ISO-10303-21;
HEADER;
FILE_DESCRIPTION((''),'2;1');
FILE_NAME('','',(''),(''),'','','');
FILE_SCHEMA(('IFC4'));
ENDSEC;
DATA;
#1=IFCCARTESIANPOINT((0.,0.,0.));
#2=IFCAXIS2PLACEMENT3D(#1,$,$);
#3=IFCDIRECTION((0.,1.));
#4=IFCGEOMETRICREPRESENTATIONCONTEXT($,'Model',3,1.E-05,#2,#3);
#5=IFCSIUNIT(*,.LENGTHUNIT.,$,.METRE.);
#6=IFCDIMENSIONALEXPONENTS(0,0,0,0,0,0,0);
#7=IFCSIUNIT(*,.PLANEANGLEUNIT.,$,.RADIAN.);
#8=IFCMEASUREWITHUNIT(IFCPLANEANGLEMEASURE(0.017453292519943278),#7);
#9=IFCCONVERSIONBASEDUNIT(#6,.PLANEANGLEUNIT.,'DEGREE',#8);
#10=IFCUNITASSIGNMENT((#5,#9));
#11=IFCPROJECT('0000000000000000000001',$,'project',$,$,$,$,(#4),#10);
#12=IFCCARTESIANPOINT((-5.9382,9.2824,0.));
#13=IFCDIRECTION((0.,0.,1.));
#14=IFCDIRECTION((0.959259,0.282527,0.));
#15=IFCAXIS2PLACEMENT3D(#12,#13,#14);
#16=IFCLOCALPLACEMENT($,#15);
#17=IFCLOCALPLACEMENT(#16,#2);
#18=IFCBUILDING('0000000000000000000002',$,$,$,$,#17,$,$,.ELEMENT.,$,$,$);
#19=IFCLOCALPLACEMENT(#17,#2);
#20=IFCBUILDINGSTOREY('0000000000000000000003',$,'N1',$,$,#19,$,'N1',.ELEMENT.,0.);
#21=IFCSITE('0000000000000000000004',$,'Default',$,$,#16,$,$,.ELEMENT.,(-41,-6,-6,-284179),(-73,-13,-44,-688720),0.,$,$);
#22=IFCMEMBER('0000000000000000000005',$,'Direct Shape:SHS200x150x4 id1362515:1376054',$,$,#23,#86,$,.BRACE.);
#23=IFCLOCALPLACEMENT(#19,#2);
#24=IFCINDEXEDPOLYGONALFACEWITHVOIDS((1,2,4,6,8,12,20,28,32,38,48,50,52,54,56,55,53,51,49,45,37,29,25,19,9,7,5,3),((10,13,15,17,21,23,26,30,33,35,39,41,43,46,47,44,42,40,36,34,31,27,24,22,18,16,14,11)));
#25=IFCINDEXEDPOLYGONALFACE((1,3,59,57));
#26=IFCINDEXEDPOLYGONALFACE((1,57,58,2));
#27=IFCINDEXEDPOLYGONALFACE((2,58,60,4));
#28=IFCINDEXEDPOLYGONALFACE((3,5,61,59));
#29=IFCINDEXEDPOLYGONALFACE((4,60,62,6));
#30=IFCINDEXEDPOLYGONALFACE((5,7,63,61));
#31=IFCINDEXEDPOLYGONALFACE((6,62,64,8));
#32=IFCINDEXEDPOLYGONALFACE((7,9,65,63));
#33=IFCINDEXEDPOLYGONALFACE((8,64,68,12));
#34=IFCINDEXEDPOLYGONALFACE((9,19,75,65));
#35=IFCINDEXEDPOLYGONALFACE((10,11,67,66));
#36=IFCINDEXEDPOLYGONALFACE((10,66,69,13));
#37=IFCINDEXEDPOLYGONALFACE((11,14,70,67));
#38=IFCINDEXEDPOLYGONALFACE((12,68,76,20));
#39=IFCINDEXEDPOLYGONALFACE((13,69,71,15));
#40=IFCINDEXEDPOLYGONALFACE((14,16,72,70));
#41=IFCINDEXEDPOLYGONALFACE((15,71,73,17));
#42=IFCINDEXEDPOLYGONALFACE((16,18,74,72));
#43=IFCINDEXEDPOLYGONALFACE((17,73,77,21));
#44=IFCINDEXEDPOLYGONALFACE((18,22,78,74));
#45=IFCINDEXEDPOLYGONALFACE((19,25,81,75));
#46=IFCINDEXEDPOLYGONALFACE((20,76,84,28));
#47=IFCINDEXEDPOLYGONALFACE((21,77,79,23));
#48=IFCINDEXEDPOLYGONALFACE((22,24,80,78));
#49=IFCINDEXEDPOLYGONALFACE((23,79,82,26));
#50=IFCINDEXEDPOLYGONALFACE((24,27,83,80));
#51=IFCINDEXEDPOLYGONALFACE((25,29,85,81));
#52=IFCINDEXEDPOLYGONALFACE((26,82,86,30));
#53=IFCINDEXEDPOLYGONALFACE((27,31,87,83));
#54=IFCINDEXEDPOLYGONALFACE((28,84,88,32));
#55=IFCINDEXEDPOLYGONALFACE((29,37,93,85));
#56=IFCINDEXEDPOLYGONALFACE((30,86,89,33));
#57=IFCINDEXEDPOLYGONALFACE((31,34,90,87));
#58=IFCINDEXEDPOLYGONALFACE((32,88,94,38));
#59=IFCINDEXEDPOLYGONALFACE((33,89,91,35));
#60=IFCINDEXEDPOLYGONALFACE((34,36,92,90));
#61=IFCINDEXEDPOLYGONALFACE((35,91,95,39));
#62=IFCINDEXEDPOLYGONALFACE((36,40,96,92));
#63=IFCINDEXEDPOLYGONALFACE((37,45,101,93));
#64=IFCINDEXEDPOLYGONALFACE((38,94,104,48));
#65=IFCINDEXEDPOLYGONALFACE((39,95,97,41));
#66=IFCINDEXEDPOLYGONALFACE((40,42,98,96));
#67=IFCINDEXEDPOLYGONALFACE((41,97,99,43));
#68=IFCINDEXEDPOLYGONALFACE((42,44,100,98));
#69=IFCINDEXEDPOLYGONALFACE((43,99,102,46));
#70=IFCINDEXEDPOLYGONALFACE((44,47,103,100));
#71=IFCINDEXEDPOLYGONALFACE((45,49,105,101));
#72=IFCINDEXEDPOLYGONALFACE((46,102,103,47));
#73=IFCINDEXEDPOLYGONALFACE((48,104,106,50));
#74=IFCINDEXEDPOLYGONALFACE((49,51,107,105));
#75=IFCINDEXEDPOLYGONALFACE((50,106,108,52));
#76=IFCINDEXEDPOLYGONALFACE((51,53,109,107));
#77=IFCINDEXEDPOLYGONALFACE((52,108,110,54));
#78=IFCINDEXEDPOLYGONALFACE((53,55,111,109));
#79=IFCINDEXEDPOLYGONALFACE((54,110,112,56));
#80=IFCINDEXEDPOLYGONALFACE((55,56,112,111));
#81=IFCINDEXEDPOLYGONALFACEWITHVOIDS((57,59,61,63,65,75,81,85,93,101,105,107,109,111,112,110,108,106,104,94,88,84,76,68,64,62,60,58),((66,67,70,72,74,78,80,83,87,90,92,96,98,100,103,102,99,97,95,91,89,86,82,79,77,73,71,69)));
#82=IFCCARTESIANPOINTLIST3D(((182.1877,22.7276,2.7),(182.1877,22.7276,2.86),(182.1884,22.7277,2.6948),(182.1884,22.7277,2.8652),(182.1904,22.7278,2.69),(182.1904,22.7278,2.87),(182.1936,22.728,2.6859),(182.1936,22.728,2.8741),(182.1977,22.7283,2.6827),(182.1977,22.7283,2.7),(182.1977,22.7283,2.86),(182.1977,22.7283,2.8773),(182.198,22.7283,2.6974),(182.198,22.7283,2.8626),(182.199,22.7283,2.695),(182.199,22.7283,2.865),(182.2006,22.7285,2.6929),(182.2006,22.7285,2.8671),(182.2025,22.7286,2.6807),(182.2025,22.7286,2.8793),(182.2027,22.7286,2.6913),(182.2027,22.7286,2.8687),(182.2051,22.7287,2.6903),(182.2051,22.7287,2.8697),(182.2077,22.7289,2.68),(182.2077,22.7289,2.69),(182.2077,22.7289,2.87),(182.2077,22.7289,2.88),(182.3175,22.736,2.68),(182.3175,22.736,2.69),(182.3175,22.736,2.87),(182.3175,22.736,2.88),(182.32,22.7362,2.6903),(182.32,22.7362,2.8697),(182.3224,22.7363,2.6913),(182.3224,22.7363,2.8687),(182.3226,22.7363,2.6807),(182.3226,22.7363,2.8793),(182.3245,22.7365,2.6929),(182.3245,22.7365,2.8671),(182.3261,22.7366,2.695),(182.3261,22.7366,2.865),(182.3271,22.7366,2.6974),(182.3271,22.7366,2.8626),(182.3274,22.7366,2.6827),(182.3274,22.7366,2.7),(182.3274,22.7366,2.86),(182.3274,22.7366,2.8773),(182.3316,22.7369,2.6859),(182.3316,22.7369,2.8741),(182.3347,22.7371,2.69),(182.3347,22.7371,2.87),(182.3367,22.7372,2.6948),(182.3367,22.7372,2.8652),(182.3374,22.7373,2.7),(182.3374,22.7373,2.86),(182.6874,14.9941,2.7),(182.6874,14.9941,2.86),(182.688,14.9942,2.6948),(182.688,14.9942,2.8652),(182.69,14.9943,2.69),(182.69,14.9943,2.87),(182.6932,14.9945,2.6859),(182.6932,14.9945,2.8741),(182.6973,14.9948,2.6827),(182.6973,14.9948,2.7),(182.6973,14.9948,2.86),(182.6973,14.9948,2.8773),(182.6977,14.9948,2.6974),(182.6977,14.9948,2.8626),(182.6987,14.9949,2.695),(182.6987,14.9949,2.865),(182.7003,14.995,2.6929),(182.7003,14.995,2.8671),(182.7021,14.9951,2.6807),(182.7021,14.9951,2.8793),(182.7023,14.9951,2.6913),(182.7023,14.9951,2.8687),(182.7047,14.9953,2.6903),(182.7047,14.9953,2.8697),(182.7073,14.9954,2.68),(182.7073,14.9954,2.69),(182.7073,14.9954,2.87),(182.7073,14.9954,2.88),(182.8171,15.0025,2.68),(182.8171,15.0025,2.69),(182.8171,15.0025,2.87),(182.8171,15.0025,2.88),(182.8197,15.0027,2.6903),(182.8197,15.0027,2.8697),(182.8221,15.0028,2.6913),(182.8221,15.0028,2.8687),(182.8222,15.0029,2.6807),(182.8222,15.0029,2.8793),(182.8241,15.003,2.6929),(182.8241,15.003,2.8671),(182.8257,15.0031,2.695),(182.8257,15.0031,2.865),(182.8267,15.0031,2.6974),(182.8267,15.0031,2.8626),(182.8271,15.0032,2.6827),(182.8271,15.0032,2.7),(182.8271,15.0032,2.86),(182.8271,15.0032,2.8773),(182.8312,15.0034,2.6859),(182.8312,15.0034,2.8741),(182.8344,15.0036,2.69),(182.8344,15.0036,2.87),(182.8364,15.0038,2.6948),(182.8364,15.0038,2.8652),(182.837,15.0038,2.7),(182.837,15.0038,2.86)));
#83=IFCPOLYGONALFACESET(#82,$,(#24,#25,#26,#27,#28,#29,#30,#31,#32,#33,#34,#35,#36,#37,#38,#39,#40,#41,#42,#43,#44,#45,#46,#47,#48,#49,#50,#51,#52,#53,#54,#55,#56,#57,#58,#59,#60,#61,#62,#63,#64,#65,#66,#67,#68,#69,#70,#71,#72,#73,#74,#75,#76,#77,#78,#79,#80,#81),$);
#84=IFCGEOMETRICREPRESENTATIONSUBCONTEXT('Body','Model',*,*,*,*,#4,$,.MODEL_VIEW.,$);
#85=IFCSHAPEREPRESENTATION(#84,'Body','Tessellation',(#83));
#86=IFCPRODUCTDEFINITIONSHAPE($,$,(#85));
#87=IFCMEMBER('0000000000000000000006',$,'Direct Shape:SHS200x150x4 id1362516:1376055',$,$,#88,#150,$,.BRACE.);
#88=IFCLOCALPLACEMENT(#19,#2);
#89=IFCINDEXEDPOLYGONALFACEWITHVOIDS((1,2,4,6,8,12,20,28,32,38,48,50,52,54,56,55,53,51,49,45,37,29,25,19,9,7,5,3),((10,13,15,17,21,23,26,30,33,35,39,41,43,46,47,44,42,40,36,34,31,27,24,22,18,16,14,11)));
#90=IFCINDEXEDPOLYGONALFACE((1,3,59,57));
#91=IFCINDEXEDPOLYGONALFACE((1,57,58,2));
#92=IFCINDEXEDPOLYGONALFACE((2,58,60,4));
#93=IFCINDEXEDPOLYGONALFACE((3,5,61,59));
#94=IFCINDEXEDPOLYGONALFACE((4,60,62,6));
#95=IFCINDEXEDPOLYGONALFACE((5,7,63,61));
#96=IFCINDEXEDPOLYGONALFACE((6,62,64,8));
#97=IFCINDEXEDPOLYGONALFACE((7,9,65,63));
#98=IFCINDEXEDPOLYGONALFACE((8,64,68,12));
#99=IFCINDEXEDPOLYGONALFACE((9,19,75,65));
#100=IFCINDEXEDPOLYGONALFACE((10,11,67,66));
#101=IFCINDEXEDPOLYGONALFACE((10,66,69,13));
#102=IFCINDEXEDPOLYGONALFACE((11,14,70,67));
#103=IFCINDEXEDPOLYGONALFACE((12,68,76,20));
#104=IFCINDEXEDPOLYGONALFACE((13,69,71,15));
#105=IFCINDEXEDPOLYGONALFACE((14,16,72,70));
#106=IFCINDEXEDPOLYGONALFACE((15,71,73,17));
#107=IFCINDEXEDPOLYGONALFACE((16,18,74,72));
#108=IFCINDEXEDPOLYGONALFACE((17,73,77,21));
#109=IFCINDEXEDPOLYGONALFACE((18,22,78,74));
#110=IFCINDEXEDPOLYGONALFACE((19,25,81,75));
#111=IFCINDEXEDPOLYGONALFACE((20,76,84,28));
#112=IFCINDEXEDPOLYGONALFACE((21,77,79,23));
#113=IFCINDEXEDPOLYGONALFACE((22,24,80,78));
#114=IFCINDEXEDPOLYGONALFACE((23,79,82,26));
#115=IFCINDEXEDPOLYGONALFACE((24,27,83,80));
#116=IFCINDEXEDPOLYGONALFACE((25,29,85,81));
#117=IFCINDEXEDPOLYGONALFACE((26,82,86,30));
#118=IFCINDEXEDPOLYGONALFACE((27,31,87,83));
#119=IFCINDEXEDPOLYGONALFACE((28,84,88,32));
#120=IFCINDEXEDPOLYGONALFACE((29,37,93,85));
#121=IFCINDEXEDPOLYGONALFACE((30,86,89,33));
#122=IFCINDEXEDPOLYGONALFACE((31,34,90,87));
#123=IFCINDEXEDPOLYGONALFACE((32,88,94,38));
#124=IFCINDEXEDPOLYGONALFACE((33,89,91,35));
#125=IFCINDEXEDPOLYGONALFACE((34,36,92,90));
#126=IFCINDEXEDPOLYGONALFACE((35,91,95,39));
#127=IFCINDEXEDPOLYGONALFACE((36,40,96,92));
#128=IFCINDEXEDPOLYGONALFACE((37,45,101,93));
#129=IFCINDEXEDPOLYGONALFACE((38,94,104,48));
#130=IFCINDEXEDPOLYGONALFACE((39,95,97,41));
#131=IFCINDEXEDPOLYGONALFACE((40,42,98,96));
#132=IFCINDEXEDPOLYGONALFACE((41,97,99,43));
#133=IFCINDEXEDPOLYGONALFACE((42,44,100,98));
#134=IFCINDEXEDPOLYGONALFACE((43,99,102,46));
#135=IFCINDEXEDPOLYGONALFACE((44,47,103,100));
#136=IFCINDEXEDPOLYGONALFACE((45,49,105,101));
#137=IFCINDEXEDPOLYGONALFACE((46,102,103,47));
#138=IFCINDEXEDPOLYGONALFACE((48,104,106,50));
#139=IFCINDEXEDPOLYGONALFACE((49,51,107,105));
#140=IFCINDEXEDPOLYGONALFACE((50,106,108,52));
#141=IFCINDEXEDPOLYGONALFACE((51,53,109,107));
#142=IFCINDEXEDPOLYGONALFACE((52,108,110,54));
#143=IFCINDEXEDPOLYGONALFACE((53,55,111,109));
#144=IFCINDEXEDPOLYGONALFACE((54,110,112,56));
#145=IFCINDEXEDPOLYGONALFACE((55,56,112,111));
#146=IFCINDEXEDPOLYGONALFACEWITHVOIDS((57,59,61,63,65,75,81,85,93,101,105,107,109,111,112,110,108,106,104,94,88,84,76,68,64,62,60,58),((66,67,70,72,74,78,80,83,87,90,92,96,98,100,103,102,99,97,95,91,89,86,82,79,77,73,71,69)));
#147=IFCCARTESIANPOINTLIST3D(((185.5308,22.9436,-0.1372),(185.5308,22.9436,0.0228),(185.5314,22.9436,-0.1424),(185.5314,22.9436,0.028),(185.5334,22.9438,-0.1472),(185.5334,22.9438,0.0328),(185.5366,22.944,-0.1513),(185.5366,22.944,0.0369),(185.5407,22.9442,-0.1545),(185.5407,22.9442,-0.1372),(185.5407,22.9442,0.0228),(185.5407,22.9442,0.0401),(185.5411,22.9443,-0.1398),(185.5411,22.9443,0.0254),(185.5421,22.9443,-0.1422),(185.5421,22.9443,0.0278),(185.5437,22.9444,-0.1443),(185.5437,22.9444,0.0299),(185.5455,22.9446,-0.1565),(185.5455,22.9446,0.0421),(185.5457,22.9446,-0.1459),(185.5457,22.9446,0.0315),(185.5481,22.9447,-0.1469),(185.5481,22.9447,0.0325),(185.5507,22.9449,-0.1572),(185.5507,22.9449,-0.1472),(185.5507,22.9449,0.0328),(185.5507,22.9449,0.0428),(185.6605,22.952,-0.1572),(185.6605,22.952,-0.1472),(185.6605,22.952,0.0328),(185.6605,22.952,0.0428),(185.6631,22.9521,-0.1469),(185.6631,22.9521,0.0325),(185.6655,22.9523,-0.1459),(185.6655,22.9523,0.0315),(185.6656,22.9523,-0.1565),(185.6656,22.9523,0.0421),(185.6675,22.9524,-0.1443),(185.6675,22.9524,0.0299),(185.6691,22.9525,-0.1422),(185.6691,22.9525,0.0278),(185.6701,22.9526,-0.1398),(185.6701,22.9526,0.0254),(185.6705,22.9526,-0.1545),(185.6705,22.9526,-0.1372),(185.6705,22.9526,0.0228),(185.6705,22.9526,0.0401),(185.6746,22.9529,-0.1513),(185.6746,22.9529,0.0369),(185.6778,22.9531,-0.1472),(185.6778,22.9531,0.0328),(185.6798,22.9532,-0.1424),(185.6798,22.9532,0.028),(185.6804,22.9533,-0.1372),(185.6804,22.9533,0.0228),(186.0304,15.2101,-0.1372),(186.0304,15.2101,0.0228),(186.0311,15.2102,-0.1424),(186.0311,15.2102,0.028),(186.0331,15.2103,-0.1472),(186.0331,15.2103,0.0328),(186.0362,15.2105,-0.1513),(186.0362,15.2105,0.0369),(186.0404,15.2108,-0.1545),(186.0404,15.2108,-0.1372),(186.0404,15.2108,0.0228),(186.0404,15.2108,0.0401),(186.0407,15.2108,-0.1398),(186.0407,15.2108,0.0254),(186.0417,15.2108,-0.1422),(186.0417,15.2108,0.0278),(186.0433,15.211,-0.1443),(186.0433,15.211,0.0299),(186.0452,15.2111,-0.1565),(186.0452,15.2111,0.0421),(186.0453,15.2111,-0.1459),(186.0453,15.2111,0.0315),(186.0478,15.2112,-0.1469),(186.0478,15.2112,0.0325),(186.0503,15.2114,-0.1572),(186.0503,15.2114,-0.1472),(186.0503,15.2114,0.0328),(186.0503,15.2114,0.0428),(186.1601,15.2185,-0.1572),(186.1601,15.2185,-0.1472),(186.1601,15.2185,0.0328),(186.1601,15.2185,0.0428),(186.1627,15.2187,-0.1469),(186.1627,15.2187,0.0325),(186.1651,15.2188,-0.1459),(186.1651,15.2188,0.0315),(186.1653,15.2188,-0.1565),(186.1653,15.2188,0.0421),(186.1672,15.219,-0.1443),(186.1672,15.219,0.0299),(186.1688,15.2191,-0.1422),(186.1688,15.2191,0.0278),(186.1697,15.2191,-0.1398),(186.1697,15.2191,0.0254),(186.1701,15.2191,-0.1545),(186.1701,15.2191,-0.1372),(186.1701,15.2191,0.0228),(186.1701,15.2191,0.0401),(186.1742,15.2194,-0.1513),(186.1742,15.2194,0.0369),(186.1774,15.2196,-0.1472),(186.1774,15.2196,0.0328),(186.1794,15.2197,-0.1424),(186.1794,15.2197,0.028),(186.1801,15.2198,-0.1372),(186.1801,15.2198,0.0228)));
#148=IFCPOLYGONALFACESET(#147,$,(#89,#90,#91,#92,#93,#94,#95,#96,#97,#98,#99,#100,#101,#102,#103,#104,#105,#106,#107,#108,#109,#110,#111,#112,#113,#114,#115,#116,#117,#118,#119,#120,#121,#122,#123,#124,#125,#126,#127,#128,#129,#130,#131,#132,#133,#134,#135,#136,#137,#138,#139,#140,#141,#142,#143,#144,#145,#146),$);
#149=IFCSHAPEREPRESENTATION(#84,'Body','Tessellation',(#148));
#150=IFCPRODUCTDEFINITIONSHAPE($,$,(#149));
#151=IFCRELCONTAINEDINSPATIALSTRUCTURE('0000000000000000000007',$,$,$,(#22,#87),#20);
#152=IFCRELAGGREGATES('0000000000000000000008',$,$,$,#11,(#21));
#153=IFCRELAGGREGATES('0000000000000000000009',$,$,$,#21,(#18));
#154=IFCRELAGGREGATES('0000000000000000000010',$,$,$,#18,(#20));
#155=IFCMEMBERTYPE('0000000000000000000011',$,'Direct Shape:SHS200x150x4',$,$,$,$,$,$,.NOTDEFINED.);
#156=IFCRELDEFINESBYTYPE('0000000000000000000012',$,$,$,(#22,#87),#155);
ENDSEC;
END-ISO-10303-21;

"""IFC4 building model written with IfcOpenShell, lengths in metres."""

from ifc_helpers import new_model, entity, si_unit, converted_unit, direction, frame, frame_2d, origin, place, context, subcontext, project, spatial, polyline, circle_curve, parameter, trimmed, segment, composite_curve, outline, extrude, type_object, element, save


model = new_model("IFC4")

# Units and contexts
model_context = context("Model", 3, precision=1e-05, world=origin(), true_north=direction((0.0, 1.0)))
body_context = subcontext(model_context, "Body", "Model", "MODEL_VIEW")
ifc_project = project(units=[si_unit("LENGTHUNIT", "METRE"), converted_unit("PLANEANGLEUNIT", "DEGREE", entity("IfcPlaneAngleMeasure", 0.017453292519943278), si_unit("PLANEANGLEUNIT", "RADIAN"), dimensions=[0, 0, 0, 0, 0, 0, 0])], contexts=[model_context])

# Site, building, storey
site_placement = place(None, frame((-5.9382, 9.2824, 0.0), z_axis=(0.0, 0.0, 1.0), x_axis=(0.959259, 0.282527, 0.0)))
site = spatial("IfcSite", under=ifc_project, at=site_placement, Name="Default", CompositionType="ELEMENT", RefLatitude=(-41, -6, -6, -284179), RefLongitude=(-73, -13, -44, -688720), RefElevation=0.0)
building_placement = place(site_placement, origin())
building = spatial("IfcBuilding", under=site, at=building_placement, CompositionType="ELEMENT")
storey_placement = place(building_placement, origin())
storey = spatial("IfcBuildingStorey", under=building, at=storey_placement, Name="N1", LongName="N1", CompositionType="ELEMENT", Elevation=0.0)

# Members
member_type_1 = type_object("IfcMemberType", Name="Direct Shape:SHS200x150x4", PredefinedType="NOTDEFINED")
member_1_placement = place(storey_placement, origin())
element("IfcMember", 1, at=member_1_placement, inside=storey, type_object=member_type_1, Name="Direct Shape:SHS200x150x4 id1362515:1376054", PredefinedType="BRACE", context=body_context, shape_type="SweptSolid", body=[
    extrude(outline(composite_curve([segment(polyline([(-0.08, -0.075), (0.08, -0.075)]), True, "CONTINUOUS"), segment(trimmed(circle_curve(frame_2d((0.08, -0.055), x_axis=(0.0, 1.0)), 0.02), [parameter(180.0)], [parameter(270.0)], True, "PARAMETER"), True, "CONTINUOUS"), segment(polyline([(0.1, -0.055), (0.1, 0.055)]), True, "CONTINUOUS"), segment(trimmed(circle_curve(frame_2d((0.08, 0.055), x_axis=(0.0, 1.0)), 0.02), [parameter(270.0)], [parameter(0.0)], True, "PARAMETER"), True, "CONTINUOUS"), segment(polyline([(0.08, 0.075), (-0.08, 0.075)]), True, "CONTINUOUS"), segment(trimmed(circle_curve(frame_2d((-0.08, 0.055), x_axis=(0.0, 1.0)), 0.02), [parameter(360.0)], [parameter(90.0)], True, "PARAMETER"), True, "CONTINUOUS"), segment(polyline([(-0.1, 0.055), (-0.1, -0.055)]), True, "CONTINUOUS"), segment(trimmed(circle_curve(frame_2d((-0.08, -0.055), x_axis=(0.0, 1.0)), 0.02), [parameter(90.0)], [parameter(180.0)], True, "PARAMETER"), True, "CONTINUOUS")], self_intersect=False), holes=[composite_curve([segment(trimmed(circle_curve(frame_2d((-0.08, 0.055), x_axis=(0.0, 1.0)), 0.01), [parameter(360.0)], [parameter(90.0)], True, "PARAMETER"), False, "CONTINUOUS"), segment(polyline([(-0.08, 0.065), (0.08, 0.065)]), True, "CONTINUOUS"), segment(trimmed(circle_curve(frame_2d((0.08, 0.055), x_axis=(0.0, 1.0)), 0.01), [parameter(270.0)], [parameter(0.0)], True, "PARAMETER"), False, "CONTINUOUS"), segment(polyline([(0.09, 0.055), (0.09, -0.055)]), True, "CONTINUOUS"), segment(trimmed(circle_curve(frame_2d((0.08, -0.055), x_axis=(0.0, 1.0)), 0.01), [parameter(180.0)], [parameter(270.0)], True, "PARAMETER"), False, "CONTINUOUS"), segment(polyline([(0.08, -0.065), (-0.08, -0.065)]), True, "CONTINUOUS"), segment(trimmed(circle_curve(frame_2d((-0.08, -0.055), x_axis=(0.0, 1.0)), 0.01), [parameter(90.0)], [parameter(180.0)], True, "PARAMETER"), False, "CONTINUOUS"), segment(polyline([(-0.09, -0.055), (-0.09, 0.055)]), True, "CONTINUOUS")], self_intersect=False)]), frame((182.7622, 14.999, 2.78), z_axis=(-0.064471, 0.99792, 0.0), x_axis=(0.0, 0.0, -1.0)), (0.0, 0.0, 1.0), 7.7496),
])
member_2_placement = place(storey_placement, origin())
element("IfcMember", 2, at=member_2_placement, inside=storey, type_object=member_type_1, Name="Direct Shape:SHS200x150x4 id1362516:1376055", PredefinedType="BRACE", context=body_context, shape_type="SweptSolid", body=[
    extrude(outline(composite_curve([segment(polyline([(-0.08, -0.075), (0.08, -0.075)]), True, "CONTINUOUS"), segment(trimmed(circle_curve(frame_2d((0.08, -0.055), x_axis=(0.0, 1.0)), 0.02), [parameter(180.0)], [parameter(270.0)], True, "PARAMETER"), True, "CONTINUOUS"), segment(polyline([(0.1, -0.055), (0.1, 0.055)]), True, "CONTINUOUS"), segment(trimmed(circle_curve(frame_2d((0.08, 0.055), x_axis=(0.0, 1.0)), 0.02), [parameter(270.0)], [parameter(0.0)], True, "PARAMETER"), True, "CONTINUOUS"), segment(polyline([(0.08, 0.075), (-0.08, 0.075)]), True, "CONTINUOUS"), segment(trimmed(circle_curve(frame_2d((-0.08, 0.055), x_axis=(0.0, 1.0)), 0.02), [parameter(360.0)], [parameter(90.0)], True, "PARAMETER"), True, "CONTINUOUS"), segment(polyline([(-0.1, 0.055), (-0.1, -0.055)]), True, "CONTINUOUS"), segment(trimmed(circle_curve(frame_2d((-0.08, -0.055), x_axis=(0.0, 1.0)), 0.02), [parameter(90.0)], [parameter(180.0)], True, "PARAMETER"), True, "CONTINUOUS")], self_intersect=False), holes=[composite_curve([segment(trimmed(circle_curve(frame_2d((-0.08, 0.055), x_axis=(0.0, 1.0)), 0.01), [parameter(360.0)], [parameter(90.0)], True, "PARAMETER"), False, "CONTINUOUS"), segment(polyline([(-0.08, 0.065), (0.08, 0.065)]), True, "CONTINUOUS"), segment(trimmed(circle_curve(frame_2d((0.08, 0.055), x_axis=(0.0, 1.0)), 0.01), [parameter(270.0)], [parameter(0.0)], True, "PARAMETER"), False, "CONTINUOUS"), segment(polyline([(0.09, 0.055), (0.09, -0.055)]), True, "CONTINUOUS"), segment(trimmed(circle_curve(frame_2d((0.08, -0.055), x_axis=(0.0, 1.0)), 0.01), [parameter(180.0)], [parameter(270.0)], True, "PARAMETER"), False, "CONTINUOUS"), segment(polyline([(0.08, -0.065), (-0.08, -0.065)]), True, "CONTINUOUS"), segment(trimmed(circle_curve(frame_2d((-0.08, -0.055), x_axis=(0.0, 1.0)), 0.01), [parameter(90.0)], [parameter(180.0)], True, "PARAMETER"), False, "CONTINUOUS"), segment(polyline([(-0.09, -0.055), (-0.09, 0.055)]), True, "CONTINUOUS")], self_intersect=False)]), frame((186.1052, 15.215, -0.0572), z_axis=(-0.064471, 0.99792, 0.0), x_axis=(0.0, 0.0, -1.0)), (0.0, 0.0, 1.0), 7.7496),
])

save(model, "model.ifc")
